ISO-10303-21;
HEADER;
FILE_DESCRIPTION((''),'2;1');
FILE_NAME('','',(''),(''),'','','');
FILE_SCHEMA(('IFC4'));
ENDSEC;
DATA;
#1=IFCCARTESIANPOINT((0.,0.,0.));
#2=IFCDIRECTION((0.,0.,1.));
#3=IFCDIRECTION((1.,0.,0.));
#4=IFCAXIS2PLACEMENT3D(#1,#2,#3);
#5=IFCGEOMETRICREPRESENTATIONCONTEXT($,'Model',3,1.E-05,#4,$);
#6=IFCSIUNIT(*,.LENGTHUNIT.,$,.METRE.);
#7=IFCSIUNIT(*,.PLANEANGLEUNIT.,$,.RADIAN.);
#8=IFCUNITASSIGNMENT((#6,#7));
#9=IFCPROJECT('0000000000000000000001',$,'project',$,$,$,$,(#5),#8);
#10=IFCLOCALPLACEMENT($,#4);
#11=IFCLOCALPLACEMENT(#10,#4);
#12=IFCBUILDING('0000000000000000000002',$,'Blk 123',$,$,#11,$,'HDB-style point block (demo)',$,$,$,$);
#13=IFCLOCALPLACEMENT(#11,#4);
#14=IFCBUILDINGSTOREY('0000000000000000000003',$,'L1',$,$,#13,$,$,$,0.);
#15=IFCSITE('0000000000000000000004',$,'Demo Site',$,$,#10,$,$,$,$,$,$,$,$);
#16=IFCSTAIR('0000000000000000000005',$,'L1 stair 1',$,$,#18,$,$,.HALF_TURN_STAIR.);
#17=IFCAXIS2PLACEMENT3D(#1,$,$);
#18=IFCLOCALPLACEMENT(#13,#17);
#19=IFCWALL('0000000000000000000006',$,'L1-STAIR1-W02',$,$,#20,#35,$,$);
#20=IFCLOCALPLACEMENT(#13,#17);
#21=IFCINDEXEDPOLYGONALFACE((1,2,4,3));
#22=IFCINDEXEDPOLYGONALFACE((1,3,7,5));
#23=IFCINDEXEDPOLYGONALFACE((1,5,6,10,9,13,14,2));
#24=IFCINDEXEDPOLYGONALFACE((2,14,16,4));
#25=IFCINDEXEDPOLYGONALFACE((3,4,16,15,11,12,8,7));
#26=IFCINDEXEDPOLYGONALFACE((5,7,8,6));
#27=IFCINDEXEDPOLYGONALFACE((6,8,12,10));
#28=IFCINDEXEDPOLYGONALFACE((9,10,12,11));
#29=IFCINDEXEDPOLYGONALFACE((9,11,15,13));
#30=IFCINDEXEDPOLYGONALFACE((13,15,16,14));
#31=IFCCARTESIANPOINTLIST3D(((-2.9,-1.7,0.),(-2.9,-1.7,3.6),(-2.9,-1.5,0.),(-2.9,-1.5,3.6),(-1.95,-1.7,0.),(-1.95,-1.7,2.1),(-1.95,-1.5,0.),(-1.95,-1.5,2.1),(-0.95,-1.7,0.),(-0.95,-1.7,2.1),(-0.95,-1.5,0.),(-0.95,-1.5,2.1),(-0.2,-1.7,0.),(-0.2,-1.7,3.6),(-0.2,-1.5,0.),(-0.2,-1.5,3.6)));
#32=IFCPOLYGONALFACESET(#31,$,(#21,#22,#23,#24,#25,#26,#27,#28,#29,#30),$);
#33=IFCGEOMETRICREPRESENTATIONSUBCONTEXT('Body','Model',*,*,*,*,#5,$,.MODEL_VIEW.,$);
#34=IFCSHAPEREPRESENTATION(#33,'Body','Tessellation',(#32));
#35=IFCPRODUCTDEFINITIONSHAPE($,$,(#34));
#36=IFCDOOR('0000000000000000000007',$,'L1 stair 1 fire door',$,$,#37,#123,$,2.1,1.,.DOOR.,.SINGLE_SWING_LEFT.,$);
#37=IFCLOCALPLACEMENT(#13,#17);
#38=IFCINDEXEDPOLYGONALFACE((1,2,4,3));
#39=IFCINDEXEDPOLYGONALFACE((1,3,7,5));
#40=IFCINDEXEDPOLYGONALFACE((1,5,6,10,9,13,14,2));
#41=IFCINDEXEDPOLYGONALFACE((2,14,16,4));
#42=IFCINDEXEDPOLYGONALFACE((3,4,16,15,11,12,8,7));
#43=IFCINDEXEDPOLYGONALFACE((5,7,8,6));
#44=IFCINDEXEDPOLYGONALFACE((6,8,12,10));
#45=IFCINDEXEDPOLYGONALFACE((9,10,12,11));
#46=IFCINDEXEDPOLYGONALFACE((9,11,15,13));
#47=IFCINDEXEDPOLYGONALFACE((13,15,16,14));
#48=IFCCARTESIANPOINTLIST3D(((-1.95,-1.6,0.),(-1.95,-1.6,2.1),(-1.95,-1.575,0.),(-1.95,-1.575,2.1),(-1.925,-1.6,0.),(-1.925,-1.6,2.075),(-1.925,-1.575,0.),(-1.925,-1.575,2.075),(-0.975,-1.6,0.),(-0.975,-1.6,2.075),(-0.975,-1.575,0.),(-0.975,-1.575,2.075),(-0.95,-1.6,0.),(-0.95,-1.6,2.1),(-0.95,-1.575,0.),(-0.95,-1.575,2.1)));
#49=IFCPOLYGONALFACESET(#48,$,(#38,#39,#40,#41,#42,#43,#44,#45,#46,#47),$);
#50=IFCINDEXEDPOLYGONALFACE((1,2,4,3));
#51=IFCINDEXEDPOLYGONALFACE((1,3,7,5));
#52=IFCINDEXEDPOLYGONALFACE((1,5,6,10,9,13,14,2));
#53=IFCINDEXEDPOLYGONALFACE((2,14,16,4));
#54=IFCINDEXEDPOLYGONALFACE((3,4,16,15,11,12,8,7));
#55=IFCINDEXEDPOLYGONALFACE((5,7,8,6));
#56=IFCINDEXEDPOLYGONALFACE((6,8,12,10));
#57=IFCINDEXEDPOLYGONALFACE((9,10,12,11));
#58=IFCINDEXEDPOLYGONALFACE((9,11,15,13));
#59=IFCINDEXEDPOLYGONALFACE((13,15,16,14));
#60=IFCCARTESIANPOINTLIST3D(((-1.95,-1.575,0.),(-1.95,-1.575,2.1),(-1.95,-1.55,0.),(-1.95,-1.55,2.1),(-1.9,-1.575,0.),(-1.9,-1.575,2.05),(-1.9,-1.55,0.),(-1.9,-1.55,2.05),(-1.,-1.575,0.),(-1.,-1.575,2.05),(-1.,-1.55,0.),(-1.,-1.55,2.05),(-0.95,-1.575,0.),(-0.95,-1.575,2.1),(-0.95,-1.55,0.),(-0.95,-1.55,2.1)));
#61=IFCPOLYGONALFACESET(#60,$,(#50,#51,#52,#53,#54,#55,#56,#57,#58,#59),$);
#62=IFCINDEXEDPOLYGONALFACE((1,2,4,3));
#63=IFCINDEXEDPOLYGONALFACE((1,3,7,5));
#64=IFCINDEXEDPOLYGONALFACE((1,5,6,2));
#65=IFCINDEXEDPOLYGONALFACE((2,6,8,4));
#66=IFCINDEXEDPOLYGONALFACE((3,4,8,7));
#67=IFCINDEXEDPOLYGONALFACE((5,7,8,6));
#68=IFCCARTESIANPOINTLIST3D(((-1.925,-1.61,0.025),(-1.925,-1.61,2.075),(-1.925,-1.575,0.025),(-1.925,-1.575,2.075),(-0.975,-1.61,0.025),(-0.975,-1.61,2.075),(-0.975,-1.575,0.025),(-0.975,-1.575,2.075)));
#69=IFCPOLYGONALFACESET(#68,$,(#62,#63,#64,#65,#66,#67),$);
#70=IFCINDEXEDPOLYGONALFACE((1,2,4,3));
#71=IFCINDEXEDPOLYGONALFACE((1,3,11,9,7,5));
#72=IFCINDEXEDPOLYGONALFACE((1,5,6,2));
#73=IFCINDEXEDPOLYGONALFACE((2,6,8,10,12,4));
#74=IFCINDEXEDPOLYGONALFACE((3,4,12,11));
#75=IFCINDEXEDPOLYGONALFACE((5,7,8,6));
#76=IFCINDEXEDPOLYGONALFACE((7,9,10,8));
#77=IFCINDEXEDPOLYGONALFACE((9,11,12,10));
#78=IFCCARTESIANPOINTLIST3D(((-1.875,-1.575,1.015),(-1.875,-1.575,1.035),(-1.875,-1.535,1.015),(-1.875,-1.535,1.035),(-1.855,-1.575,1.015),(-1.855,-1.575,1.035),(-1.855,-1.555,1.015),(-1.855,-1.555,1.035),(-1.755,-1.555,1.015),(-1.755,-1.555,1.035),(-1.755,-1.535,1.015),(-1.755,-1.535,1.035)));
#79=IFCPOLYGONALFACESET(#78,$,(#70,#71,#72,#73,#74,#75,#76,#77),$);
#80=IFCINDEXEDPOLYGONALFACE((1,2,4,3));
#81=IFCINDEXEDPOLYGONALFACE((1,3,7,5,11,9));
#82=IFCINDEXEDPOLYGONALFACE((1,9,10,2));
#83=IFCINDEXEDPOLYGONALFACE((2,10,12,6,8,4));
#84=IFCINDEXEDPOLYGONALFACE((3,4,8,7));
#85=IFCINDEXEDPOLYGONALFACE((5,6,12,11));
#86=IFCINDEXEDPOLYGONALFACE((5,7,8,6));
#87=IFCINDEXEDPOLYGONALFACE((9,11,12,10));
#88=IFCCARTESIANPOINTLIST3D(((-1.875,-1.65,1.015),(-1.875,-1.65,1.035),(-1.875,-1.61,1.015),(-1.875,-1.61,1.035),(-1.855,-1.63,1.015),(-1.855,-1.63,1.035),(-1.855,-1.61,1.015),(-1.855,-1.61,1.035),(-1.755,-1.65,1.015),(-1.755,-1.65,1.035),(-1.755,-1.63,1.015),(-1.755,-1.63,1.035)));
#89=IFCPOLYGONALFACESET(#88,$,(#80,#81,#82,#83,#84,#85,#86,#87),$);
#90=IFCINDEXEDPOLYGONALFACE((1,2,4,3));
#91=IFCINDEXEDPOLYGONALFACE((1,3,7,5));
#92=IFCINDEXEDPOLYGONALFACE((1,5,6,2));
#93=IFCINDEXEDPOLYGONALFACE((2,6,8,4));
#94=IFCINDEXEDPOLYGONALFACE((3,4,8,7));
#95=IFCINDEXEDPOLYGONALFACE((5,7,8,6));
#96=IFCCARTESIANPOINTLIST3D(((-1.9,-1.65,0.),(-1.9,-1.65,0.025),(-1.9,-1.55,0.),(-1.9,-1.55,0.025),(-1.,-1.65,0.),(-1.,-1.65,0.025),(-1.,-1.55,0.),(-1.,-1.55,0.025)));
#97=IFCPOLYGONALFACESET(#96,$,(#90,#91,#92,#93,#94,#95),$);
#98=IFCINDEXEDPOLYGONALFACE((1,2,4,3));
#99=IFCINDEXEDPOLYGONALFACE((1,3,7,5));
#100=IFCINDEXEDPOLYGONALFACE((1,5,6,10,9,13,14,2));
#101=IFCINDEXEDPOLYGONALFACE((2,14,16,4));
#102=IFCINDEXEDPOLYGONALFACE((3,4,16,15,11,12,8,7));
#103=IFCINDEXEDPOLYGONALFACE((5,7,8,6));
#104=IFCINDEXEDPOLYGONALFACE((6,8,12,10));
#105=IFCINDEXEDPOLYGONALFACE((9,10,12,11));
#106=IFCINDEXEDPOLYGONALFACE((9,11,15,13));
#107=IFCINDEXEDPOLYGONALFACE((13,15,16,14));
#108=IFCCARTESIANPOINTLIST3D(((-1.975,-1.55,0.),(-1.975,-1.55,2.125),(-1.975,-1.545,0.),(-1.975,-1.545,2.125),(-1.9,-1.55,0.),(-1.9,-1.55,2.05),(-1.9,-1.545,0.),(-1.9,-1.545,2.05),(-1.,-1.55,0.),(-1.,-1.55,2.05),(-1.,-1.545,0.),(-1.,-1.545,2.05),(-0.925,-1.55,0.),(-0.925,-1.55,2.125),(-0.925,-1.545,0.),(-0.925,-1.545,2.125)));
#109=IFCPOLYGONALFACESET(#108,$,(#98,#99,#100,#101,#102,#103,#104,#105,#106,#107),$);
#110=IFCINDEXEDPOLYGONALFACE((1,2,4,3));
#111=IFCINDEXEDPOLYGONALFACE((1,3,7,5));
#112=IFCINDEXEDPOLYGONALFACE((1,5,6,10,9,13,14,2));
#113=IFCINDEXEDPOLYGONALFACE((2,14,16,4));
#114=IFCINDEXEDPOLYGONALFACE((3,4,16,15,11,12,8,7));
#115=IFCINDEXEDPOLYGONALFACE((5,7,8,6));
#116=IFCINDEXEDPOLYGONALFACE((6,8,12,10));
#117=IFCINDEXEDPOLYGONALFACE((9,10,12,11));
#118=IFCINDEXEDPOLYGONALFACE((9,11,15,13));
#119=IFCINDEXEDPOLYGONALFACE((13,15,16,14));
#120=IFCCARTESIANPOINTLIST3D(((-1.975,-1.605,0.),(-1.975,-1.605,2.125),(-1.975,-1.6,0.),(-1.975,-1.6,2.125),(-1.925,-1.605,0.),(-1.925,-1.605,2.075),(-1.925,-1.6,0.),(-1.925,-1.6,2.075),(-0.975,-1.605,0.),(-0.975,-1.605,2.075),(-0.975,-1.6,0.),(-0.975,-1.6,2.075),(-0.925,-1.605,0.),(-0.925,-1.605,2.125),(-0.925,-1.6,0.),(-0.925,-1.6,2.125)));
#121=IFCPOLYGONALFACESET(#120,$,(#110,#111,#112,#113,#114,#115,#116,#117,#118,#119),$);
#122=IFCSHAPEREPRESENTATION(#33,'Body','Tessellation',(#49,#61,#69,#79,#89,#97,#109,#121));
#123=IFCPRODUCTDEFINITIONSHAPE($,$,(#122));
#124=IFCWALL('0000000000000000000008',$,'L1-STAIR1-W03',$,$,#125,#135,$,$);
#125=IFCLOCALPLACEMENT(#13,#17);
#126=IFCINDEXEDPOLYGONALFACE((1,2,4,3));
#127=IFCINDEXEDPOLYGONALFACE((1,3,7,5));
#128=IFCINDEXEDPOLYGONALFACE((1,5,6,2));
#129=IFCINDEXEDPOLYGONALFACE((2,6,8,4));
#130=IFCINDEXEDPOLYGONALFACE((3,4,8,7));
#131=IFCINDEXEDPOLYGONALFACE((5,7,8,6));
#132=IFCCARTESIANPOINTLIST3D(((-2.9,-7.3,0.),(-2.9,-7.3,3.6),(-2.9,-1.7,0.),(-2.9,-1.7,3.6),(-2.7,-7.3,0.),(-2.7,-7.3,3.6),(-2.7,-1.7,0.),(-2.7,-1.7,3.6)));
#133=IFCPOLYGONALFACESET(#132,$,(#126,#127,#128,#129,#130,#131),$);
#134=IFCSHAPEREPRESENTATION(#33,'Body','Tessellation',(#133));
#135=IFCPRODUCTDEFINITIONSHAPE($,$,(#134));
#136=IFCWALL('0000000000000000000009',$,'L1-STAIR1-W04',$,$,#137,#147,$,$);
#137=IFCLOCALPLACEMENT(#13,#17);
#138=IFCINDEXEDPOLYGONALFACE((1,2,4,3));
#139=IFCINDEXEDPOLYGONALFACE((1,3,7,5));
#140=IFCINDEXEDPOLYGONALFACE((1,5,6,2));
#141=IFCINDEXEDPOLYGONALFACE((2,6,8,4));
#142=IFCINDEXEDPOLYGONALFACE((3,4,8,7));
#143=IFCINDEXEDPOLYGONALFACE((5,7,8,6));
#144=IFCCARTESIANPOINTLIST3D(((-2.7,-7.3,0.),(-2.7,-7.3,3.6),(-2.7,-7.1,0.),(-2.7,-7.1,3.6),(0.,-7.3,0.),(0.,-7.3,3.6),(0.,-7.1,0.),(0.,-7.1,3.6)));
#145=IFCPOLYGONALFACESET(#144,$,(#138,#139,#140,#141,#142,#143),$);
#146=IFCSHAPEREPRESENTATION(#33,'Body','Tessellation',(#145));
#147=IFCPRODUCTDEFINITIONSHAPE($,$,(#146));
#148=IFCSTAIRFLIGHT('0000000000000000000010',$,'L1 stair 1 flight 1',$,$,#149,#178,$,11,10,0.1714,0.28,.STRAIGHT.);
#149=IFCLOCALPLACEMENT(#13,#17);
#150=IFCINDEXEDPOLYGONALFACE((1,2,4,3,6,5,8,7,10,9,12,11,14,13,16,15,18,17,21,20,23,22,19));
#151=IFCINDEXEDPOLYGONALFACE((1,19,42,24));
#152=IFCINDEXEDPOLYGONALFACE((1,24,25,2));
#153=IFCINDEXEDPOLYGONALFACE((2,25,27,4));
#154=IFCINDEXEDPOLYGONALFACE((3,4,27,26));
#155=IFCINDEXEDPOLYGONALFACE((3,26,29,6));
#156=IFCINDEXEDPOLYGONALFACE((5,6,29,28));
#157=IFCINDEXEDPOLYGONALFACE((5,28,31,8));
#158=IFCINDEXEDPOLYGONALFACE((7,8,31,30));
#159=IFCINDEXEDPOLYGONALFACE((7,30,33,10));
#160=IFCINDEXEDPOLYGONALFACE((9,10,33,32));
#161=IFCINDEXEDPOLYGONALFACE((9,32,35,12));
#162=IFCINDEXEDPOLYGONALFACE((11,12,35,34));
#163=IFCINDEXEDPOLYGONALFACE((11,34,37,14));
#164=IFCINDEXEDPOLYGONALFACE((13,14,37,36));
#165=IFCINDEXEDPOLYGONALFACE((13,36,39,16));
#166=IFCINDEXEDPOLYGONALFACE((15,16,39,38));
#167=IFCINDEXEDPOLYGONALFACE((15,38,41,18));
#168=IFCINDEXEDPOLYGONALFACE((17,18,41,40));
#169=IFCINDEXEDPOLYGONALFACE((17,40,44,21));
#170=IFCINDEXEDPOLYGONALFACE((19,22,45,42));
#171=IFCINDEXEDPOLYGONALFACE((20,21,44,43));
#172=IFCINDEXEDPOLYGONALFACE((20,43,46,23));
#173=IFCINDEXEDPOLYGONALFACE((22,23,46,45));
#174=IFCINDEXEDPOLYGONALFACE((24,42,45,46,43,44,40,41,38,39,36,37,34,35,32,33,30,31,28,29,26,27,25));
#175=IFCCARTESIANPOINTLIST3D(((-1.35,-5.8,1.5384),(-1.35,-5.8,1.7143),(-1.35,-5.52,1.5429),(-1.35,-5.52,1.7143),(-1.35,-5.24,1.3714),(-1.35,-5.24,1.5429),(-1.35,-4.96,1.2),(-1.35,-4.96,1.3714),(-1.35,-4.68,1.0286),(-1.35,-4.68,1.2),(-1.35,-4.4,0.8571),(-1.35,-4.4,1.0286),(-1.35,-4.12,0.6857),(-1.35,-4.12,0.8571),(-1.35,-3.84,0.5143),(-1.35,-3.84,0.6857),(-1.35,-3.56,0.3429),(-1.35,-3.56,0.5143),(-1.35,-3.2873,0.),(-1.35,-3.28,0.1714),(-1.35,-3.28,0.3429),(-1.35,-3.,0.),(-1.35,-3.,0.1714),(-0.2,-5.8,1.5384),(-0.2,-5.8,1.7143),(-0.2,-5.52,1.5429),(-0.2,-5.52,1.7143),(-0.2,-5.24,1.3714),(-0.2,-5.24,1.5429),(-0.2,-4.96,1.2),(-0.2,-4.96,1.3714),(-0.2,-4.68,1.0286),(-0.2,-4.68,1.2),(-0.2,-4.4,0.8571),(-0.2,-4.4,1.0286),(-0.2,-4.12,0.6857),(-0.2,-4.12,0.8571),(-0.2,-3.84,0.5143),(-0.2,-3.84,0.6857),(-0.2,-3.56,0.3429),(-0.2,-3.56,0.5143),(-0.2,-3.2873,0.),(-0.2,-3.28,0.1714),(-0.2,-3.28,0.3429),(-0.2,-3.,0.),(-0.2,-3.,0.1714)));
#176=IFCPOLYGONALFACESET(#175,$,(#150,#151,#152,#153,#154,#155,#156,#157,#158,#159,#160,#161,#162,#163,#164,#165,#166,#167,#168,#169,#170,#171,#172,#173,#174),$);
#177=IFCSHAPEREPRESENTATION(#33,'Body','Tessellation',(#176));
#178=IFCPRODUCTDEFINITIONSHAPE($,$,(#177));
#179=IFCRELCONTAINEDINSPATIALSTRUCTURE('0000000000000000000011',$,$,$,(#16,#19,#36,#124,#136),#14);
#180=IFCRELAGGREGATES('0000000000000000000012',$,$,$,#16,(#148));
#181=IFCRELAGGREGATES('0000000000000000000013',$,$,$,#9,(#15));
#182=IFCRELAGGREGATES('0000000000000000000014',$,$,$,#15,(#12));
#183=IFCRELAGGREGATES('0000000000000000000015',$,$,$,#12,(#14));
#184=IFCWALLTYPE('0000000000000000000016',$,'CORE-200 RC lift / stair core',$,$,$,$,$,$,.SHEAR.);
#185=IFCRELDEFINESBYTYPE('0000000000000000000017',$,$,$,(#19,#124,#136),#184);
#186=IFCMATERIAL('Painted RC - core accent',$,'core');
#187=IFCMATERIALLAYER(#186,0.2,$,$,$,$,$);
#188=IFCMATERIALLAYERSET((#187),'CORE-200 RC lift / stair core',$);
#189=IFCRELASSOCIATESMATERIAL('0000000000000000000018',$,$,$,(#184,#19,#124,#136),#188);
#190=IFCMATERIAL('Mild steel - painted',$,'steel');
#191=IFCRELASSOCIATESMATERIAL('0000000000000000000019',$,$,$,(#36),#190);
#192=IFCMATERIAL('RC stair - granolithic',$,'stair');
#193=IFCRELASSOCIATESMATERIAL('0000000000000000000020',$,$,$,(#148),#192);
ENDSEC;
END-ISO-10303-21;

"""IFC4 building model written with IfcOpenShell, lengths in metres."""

from ifc_helpers import new_model, si_unit, frame, origin_with_axes, place, context, subcontext, project, spatial, polyline, line, indexed_curve, outline, extrude, material, layer, layer_set, layer_usage, type_object, element, fill, aggregate, save


model = new_model("IFC4")

# Units and contexts
model_context = context("Model", 3, precision=1e-05, world=origin_with_axes())
body_context = subcontext(model_context, "Body", "Model", "MODEL_VIEW")
ifc_project = project(units=[si_unit("LENGTHUNIT", "METRE"), si_unit("PLANEANGLEUNIT", "RADIAN")], contexts=[model_context])

# Site, building, storey
site_placement = place(None, origin_with_axes())
site = spatial("IfcSite", under=ifc_project, at=site_placement, Name="Demo Site")
building_placement = place(site_placement, origin_with_axes())
building = spatial("IfcBuilding", under=site, at=building_placement, Name="Blk 123", LongName="HDB-style point block (demo)")
storey_placement = place(building_placement, origin_with_axes())
storey = spatial("IfcBuildingStorey", under=building, at=storey_placement, Name="L1", Elevation=0.0)

# Stair
stair_placement = place(storey_placement, frame((-2.7, -7.1, 0.0), z_axis=(0.0, 0.0, 1.0), x_axis=(1.0, 0.0, 0.0)))
stair = element("IfcStair", 1, at=stair_placement, inside=storey, Name="L1 stair 1", PredefinedType="HALF_TURN_STAIR")
ifc_material_1 = material(Name="RC stair - granolithic", Category="stair")

# Shared definitions
ifc_material_2 = material(Name="Painted RC - core accent", Category="core")
ifc_layer = layer(ifc_material_2, 0.2)
ifc_layer_set = layer_set([ifc_layer], Name="CORE-200 RC lift / stair core")
ifc_layer_usage = layer_usage(ifc_layer_set, "AXIS2", "POSITIVE", 0.0)
wall_type = type_object("IfcWallType", Name="CORE-200 RC lift / stair core", PredefinedType="SHEAR", material=ifc_layer_set)

# Wall, opening, door
wall_1_placement = place(storey_placement, frame((-0.2, -1.5, 0.0), z_axis=(0.0, 0.0, 1.0), x_axis=(-1.0, 0.0, 0.0)))
wall_1 = element("IfcWall", 2, at=wall_1_placement, inside=storey, type_object=wall_type, material=ifc_layer_usage, Name="L1-STAIR1-W02", context=body_context, shape_type="SweptSolid", body=[
    extrude(outline(indexed_curve([(0.0, 0.0), (0.0, 0.2), (2.7, 0.2), (2.7, 0.0), (0.0, 0.0)], self_intersect=False)), origin_with_axes(), (0.0, 0.0, 1.0), 3.6),
])
opening_1_placement = place(wall_1_placement, frame((0.75, -0.1, 0.0), z_axis=(0.0, 0.0, 1.0), x_axis=(1.0, 0.0, 0.0)))
opening_1 = element("IfcOpeningElement", 3, at=opening_1_placement, cuts=wall_1, context=body_context, shape_type="SweptSolid", body=[
    extrude(outline(indexed_curve([(0.0, 0.0), (0.0, 0.4), (1.0, 0.4), (1.0, 0.0), (0.0, 0.0)], self_intersect=False)), origin_with_axes(), (0.0, 0.0, 1.0), 2.1),
])
ifc_material_3 = material(Name="Mild steel - painted", Category="steel")
door_1_placement = place(opening_1_placement, frame((0.0, 0.15, 0.0), z_axis=(0.0, 0.0, 1.0), x_axis=(1.0, 0.0, 0.0)))
door_1 = element("IfcDoor", 4, at=door_1_placement, inside=storey, material=ifc_material_3, Name="L1 stair 1 fire door", OperationType="SINGLE_SWING_LEFT", OverallHeight=2.1, OverallWidth=1.0, PredefinedType="DOOR", context=body_context, shape_type="SweptSolid", body=[
    extrude(outline(indexed_curve([(0.0, 0.0), (0.0, 2.1), (1.0, 2.1), (1.0, 0.0), (0.975, 0.0), (0.975, 2.075), (0.025, 2.075), (0.025, 0.0)], segments=[line(1, 2, 3, 4, 5, 6, 7, 8, 1)])), frame((0.0, 0.025, 0.0), z_axis=(0.0, -1.0, 0.0), x_axis=(1.0, 0.0, 0.0)), (0.0, 0.0, -1.0), 0.025),
    extrude(outline(indexed_curve([(0.0, 0.0), (0.0, 2.1), (1.0, 2.1), (1.0, 0.0), (0.95, 0.0), (0.95, 2.05), (0.05, 2.05), (0.05, 0.0)], segments=[line(1, 2, 3, 4, 5, 6, 7, 8, 1)])), frame((0.0, 0.0, 0.0), z_axis=(0.0, -1.0, 0.0), x_axis=(1.0, 0.0, 0.0)), (0.0, 0.0, -1.0), 0.025),
    extrude(outline(indexed_curve([(0.0, 0.0), (0.95, 0.0), (0.95, 0.035), (0.0, 0.035)], segments=[line(1, 2, 3, 4, 1)])), frame((0.025, 0.025, 0.025), z_axis=(0.0, 0.0, 1.0), x_axis=(1.0, 0.0, 0.0)), (0.0, 0.0, 1.0), 2.05),
    extrude(outline(indexed_curve([(0.0, 0.0), (0.0, -0.04), (-0.12, -0.04), (-0.12, -0.02), (-0.02, -0.02), (-0.02, 0.0)], segments=[line(1, 2, 3, 4, 5, 6, 1)])), frame((0.925, 0.025, 1.015), z_axis=(0.0, 0.0, 1.0), x_axis=(1.0, 0.0, 0.0)), (0.0, 0.0, 1.0), 0.02),
    extrude(outline(indexed_curve([(0.0, 0.0), (0.0, 0.04), (-0.12, 0.04), (-0.12, 0.02), (-0.02, 0.02), (-0.02, 0.0)], segments=[line(1, 2, 3, 4, 5, 6, 1)])), frame((0.925, 0.06, 1.015), z_axis=(0.0, 0.0, 1.0), x_axis=(1.0, 0.0, 0.0)), (0.0, 0.0, 1.0), 0.02),
    extrude(outline(indexed_curve([(0.0, 0.0), (0.9, 0.0), (0.9, 0.1), (0.0, 0.1)], segments=[line(1, 2, 3, 4, 1)])), frame((0.05, 0.0, 0.0), z_axis=(0.0, 0.0, 1.0), x_axis=(1.0, 0.0, 0.0)), (0.0, 0.0, 1.0), 0.025),
    extrude(outline(indexed_curve([(0.0, 0.0), (0.0, 2.125), (1.05, 2.125), (1.05, 0.0), (0.975, 0.0), (0.975, 2.05), (0.075, 2.05), (0.075, 0.0)], segments=[line(1, 2, 3, 4, 5, 6, 7, 8, 1)])), frame((-0.025, -0.005, 0.0), z_axis=(0.0, -1.0, 0.0), x_axis=(1.0, 0.0, 0.0)), (0.0, 0.0, -1.0), 0.005),
    extrude(outline(indexed_curve([(0.0, 0.0), (0.0, 2.125), (1.05, 2.125), (1.05, 0.0), (1.0, 0.0), (1.0, 2.075), (0.05, 2.075), (0.05, 0.0)], segments=[line(1, 2, 3, 4, 5, 6, 7, 8, 1)])), frame((-0.025, 0.05, 0.0), z_axis=(0.0, -1.0, 0.0), x_axis=(1.0, 0.0, 0.0)), (0.0, 0.0, -1.0), 0.005),
])
fill(opening_1, door_1)

# Walls
wall_2_placement = place(storey_placement, frame((-2.9, -1.7, 0.0), z_axis=(0.0, 0.0, 1.0), x_axis=(0.0, -1.0, 0.0)))
element("IfcWall", 5, at=wall_2_placement, inside=storey, type_object=wall_type, material=ifc_layer_usage, Name="L1-STAIR1-W03", context=body_context, shape_type="SweptSolid", body=[
    extrude(outline(indexed_curve([(0.0, 0.0), (0.0, 0.2), (5.6, 0.2), (5.6, 0.0), (0.0, 0.0)], self_intersect=False)), origin_with_axes(), (0.0, 0.0, 1.0), 3.6),
])
wall_3_placement = place(storey_placement, frame((-2.7, -7.3, 0.0), z_axis=(0.0, 0.0, 1.0), x_axis=(1.0, 0.0, 0.0)))
element("IfcWall", 6, at=wall_3_placement, inside=storey, type_object=wall_type, material=ifc_layer_usage, Name="L1-STAIR1-W04", context=body_context, shape_type="SweptSolid", body=[
    extrude(outline(indexed_curve([(0.0, 0.0), (0.0, 0.2), (2.7, 0.2), (2.7, 0.0), (0.0, 0.0)], self_intersect=False)), origin_with_axes(), (0.0, 0.0, 1.0), 3.6),
])

# Stair flight
stair_flight_1_placement = place(stair_placement, frame((2.5, 4.1, 0.0), z_axis=(0.0, 0.0, 1.0), x_axis=(1.0, 0.0, 0.0)))
stair_flight_1 = element("IfcStairFlight", 7, at=stair_flight_1_placement, material=ifc_material_1, Name="L1 stair 1 flight 1", NumberOfRisers=11, NumberOfTreads=10, PredefinedType="STRAIGHT", RiserHeight=0.1714, TreadLength=0.28, context=body_context, shape_type="SweptSolid", body=[
    extrude(outline(polyline([(0.0, 0.0), (0.0, 0.1714), (0.28, 0.1714), (0.28, 0.3429), (0.56, 0.3429), (0.56, 0.5143), (0.84, 0.5143), (0.84, 0.6857), (1.12, 0.6857), (1.12, 0.8571), (1.4, 0.8571), (1.4, 1.0286), (1.68, 1.0286), (1.68, 1.2), (1.96, 1.2), (1.96, 1.3714), (2.24, 1.3714), (2.24, 1.5429), (2.52, 1.5429), (2.52, 1.7143), (2.8, 1.7143), (2.8, 1.8857), (2.8, 1.5384), (0.2873, 0.0), (0.0, 0.0)])), frame((0.0, 0.0, 0.0), z_axis=(-1.0, 0.0, 0.0), x_axis=(0.0, -1.0, 0.0)), (0.0, 0.0, 1.0), 1.15),
])

aggregate(stair, [stair_flight_1])

save(model, "model.ifc")
